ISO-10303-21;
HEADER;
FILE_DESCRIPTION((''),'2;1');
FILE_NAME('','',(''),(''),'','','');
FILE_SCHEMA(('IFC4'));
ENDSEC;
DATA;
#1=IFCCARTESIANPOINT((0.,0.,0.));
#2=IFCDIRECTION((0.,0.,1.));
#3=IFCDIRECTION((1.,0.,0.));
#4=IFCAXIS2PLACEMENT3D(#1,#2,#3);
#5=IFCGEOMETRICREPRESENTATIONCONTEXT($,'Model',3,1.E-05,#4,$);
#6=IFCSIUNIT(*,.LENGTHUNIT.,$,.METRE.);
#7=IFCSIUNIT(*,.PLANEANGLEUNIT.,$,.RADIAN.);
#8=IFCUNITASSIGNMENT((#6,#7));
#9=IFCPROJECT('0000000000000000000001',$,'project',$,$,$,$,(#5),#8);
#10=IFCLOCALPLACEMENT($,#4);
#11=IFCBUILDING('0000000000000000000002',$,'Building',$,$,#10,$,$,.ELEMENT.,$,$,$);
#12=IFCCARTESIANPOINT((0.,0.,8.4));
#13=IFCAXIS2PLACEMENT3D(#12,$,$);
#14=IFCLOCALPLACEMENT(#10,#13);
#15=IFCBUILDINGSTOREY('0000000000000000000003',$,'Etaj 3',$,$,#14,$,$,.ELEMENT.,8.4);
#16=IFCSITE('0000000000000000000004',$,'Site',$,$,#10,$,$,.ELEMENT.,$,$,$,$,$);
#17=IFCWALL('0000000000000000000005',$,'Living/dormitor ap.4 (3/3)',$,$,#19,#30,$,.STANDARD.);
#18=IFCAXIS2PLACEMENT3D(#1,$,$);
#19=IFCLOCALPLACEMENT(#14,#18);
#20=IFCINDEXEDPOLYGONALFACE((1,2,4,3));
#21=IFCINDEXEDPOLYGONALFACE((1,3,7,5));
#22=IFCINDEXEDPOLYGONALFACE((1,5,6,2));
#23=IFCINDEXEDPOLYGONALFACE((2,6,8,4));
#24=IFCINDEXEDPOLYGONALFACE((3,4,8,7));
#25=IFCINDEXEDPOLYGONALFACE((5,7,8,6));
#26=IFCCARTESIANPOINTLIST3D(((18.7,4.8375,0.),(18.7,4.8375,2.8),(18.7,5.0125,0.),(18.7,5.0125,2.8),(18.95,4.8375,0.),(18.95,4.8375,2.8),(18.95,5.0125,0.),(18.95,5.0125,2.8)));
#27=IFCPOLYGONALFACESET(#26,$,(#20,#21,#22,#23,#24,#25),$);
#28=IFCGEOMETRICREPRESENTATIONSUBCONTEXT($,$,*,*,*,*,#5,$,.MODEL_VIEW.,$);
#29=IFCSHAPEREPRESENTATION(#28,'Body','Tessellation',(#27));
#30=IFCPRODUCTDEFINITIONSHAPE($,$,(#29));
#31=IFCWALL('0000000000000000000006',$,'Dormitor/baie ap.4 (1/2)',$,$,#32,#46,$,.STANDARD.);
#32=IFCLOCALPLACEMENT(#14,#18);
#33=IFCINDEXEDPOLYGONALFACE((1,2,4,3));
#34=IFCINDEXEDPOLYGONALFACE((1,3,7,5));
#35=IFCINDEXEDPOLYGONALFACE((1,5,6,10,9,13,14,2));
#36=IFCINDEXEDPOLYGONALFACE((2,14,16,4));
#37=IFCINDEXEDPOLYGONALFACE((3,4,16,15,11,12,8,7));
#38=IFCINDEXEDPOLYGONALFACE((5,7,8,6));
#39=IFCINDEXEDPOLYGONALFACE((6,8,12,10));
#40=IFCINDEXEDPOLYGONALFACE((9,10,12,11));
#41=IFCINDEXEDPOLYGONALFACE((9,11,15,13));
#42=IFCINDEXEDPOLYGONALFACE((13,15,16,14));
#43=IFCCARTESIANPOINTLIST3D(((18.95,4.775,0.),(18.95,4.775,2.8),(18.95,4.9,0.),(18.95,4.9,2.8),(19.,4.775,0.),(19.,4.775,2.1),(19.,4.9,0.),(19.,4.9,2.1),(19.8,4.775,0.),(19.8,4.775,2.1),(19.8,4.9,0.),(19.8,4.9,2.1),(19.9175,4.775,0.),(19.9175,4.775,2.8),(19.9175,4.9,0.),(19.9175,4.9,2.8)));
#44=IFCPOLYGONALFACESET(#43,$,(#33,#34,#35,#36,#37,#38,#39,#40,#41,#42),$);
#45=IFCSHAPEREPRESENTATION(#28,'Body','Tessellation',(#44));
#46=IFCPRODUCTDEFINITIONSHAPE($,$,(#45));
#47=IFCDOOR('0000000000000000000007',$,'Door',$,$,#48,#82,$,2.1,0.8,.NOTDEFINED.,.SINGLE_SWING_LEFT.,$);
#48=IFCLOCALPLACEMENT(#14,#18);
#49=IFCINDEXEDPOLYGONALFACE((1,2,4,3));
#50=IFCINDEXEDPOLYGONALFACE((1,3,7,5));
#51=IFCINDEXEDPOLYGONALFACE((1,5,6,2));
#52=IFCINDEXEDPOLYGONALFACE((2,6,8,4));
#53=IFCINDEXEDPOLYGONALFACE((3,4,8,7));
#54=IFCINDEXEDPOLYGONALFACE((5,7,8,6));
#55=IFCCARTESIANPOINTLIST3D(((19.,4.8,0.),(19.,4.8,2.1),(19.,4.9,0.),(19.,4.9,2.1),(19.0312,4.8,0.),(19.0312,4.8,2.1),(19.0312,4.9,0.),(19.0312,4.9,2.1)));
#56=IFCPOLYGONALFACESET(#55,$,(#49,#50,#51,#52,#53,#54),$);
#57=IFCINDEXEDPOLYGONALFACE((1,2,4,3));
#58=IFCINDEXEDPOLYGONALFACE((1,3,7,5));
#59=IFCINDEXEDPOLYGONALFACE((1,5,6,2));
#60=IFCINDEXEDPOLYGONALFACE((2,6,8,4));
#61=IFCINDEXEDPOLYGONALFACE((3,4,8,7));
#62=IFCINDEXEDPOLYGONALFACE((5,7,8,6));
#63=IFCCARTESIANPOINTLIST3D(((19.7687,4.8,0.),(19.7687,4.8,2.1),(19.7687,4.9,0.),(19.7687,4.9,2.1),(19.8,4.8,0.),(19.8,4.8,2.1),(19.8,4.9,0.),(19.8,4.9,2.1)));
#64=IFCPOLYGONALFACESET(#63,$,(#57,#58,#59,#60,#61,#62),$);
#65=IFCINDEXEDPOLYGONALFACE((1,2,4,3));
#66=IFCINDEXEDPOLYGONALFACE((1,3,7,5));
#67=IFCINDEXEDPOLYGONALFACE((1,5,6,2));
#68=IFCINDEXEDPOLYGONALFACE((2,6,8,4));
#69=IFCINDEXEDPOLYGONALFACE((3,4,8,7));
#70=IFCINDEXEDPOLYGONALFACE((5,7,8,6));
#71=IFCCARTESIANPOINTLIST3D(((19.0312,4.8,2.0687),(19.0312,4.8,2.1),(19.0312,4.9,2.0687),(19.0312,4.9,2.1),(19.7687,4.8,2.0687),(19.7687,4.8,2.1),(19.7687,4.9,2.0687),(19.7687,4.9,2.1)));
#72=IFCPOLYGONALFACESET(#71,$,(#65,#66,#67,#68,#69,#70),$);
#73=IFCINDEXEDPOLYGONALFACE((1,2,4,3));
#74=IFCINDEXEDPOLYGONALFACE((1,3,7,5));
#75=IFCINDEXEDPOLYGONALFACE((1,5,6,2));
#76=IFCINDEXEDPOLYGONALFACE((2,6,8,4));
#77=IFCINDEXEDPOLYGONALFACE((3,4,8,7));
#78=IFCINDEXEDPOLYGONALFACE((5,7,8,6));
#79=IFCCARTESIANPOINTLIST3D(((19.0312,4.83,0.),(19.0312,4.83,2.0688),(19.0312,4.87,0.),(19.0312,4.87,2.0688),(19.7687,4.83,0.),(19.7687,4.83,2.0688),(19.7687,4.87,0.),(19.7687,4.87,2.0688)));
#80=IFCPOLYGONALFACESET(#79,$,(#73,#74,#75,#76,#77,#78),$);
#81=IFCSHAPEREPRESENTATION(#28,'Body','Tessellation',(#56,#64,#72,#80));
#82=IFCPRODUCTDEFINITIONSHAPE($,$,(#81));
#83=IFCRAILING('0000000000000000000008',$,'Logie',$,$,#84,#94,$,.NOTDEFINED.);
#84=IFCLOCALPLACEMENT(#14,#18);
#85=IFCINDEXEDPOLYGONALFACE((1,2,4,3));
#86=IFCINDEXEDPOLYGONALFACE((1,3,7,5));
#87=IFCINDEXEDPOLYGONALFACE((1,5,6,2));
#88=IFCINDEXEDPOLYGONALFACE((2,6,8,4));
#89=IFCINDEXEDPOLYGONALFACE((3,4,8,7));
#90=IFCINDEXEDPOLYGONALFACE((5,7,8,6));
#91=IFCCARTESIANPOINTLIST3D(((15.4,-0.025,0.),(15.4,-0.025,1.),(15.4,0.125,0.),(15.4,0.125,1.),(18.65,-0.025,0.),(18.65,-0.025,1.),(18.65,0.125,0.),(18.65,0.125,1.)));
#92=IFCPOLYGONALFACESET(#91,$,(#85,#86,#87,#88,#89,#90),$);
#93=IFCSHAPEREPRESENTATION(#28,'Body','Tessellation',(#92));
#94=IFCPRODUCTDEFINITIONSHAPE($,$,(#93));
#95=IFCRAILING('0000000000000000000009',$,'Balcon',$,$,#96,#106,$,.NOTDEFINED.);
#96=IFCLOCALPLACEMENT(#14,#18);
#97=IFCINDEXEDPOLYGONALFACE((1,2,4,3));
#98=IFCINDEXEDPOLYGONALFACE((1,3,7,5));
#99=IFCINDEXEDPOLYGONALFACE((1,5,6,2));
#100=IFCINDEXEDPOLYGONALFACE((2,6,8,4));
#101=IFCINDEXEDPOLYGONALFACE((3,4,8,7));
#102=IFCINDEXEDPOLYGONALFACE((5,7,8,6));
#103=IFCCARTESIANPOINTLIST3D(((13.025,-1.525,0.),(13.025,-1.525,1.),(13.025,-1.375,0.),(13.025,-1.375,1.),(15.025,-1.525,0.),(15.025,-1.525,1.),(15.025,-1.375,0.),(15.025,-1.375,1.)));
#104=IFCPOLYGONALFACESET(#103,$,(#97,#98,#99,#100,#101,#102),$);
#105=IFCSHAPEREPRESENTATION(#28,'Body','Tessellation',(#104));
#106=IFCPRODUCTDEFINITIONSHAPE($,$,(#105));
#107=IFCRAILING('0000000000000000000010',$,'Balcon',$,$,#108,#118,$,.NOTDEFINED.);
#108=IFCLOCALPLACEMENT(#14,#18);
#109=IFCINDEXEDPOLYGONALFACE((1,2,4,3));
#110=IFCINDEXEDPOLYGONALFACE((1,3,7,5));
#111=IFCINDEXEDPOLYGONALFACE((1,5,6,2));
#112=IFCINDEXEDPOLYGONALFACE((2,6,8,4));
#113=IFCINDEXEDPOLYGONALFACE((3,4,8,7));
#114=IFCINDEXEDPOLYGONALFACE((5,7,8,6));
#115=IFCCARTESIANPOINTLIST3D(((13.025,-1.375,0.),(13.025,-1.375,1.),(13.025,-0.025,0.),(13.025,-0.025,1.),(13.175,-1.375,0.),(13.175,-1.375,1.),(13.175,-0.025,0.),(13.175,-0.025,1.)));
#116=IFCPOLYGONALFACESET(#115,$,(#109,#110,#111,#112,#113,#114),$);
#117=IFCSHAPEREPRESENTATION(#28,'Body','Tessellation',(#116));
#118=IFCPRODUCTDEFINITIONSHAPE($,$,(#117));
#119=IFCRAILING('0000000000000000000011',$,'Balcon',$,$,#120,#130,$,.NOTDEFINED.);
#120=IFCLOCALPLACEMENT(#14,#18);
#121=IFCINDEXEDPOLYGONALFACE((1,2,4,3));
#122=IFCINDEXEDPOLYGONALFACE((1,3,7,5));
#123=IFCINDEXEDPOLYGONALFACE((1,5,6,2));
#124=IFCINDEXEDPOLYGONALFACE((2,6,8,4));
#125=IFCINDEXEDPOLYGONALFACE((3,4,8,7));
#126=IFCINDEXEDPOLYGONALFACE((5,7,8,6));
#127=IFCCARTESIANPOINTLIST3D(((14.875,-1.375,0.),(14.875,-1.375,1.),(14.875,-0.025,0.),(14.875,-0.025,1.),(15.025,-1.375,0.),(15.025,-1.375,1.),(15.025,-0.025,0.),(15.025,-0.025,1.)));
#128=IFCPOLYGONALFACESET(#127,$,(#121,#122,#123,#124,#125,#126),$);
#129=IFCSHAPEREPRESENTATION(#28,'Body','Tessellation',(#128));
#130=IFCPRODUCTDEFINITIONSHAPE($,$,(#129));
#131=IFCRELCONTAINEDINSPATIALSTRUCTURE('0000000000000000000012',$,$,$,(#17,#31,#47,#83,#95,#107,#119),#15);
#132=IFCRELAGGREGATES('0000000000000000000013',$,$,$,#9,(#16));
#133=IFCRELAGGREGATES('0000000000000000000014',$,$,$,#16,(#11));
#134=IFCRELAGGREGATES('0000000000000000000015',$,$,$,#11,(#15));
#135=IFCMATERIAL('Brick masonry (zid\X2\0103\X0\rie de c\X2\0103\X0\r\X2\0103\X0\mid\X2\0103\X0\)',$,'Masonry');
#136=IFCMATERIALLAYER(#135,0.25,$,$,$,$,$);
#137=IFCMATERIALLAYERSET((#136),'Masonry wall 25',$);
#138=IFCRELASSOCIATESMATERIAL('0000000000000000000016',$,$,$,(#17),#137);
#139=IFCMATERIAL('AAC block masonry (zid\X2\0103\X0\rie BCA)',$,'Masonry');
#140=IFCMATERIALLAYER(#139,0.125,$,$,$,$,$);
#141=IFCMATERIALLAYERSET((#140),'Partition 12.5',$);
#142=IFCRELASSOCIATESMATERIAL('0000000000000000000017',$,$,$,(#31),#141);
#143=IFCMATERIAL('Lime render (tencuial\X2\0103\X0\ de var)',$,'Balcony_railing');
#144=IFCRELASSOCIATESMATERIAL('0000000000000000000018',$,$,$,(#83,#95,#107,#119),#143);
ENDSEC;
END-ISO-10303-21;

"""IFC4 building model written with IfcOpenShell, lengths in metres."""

from ifc_helpers import new_model, si_unit, frame, frame_2d, origin, origin_with_axes, origin_2d, place, context, subcontext, project, spatial, polyline, rectangle, outline, extrude, material, layer, layer_set, layer_usage, element, fill, save


model = new_model("IFC4")

# Units and contexts
model_context = context("Model", 3, precision=1e-05, world=origin_with_axes())
sub_context = subcontext(model_context, None, None, "MODEL_VIEW")
ifc_project = project(units=[si_unit("LENGTHUNIT", "METRE"), si_unit("PLANEANGLEUNIT", "RADIAN")], contexts=[model_context])

# Site, building, storey
placement = place(None, origin_with_axes())
site = spatial("IfcSite", under=ifc_project, at=placement, Name="Site", CompositionType="ELEMENT")
building = spatial("IfcBuilding", under=site, at=placement, Name="Building", CompositionType="ELEMENT")
storey_placement = place(placement, frame((0.0, 0.0, 8.4)))
storey = spatial("IfcBuildingStorey", under=building, at=storey_placement, Name="Etaj 3", CompositionType="ELEMENT", Elevation=8.4)

# Shared definitions
ifc_material_1 = material(Name="Brick masonry (zidărie de cărămidă)", Category="Masonry")

# Wall
ifc_layer_1 = layer(ifc_material_1, 0.25)
ifc_layer_set_1 = layer_set([ifc_layer_1], Name="Masonry wall 25")
ifc_layer_usage_1 = layer_usage(ifc_layer_set_1, "AXIS2", "POSITIVE", -0.125)
wall_1_placement = place(storey_placement, frame((18.825, 4.8375, 0.0), x_axis=(0.0, 1.0, 0.0)))
element("IfcWall", 1, at=wall_1_placement, inside=storey, material=ifc_layer_usage_1, Name="Living/dormitor ap.4 (3/3)", PredefinedType="STANDARD", context=sub_context, shape_type="SweptSolid", body=[
    extrude(rectangle(XDim=0.175, YDim=0.25, at=frame_2d((0.0875, 0.0))), origin(), (0.0, 0.0, 1.0), 2.8),
])

# Wall, opening, door
ifc_material_2 = material(Name="AAC block masonry (zidărie BCA)", Category="Masonry")
ifc_layer_2 = layer(ifc_material_2, 0.125)
ifc_layer_set_2 = layer_set([ifc_layer_2], Name="Partition 12.5")
ifc_layer_usage_2 = layer_usage(ifc_layer_set_2, "AXIS2", "POSITIVE", -0.0625)
wall_2_placement = place(storey_placement, frame((18.95, 4.8375, 0.0), x_axis=(1.0, 0.0, 0.0)))
wall_2 = element("IfcWall", 2, at=wall_2_placement, inside=storey, material=ifc_layer_usage_2, Name="Dormitor/baie ap.4 (1/2)", PredefinedType="STANDARD", context=sub_context, shape_type="SweptSolid", body=[
    extrude(rectangle(XDim=0.9675, YDim=0.125, at=frame_2d((0.4838, 0.0))), origin(), (0.0, 0.0, 1.0), 2.8),
])
opening_1_placement = place(wall_2_placement, frame((0.45, 0.1125, 0.0), z_axis=(0.0, -1.0, 0.0), x_axis=(1.0, 0.0, 0.0)))
opening_1 = element("IfcOpeningElement", 3, at=opening_1_placement, cuts=wall_2, PredefinedType="OPENING", context=sub_context, shape_type="SweptSolid", body=[
    extrude(rectangle(XDim=0.8, YDim=2.1, at=frame_2d((0.0, 1.05))), origin(), (0.0, 0.0, 1.0), 0.225),
])
door_placement = place(wall_2_placement, frame((0.45, 0.0625, 0.0), z_axis=(0.0, -1.0, 0.0), x_axis=(1.0, 0.0, 0.0)))
door = element("IfcDoor", 4, at=door_placement, inside=storey, Name="Door", OperationType="SINGLE_SWING_LEFT", OverallHeight=2.1, OverallWidth=0.8, PredefinedType="NOTDEFINED", context=sub_context, shape_type="SweptSolid", body=[
    extrude(rectangle(XDim=0.0312, YDim=2.1, at=origin_2d()), frame((-0.3844, 1.05, 0.0)), (0.0, 0.0, 1.0), 0.1),
    extrude(rectangle(XDim=0.0312, YDim=2.1, at=origin_2d()), frame((0.3844, 1.05, 0.0)), (0.0, 0.0, 1.0), 0.1),
    extrude(rectangle(XDim=0.7375, YDim=0.0312, at=origin_2d()), frame((0.0, 2.0844, 0.0)), (0.0, 0.0, 1.0), 0.1),
    extrude(rectangle(XDim=0.7375, YDim=2.0688, at=origin_2d()), frame((0.0, 1.0344, 0.03)), (0.0, 0.0, 1.0), 0.04),
])
fill(opening_1, door)

# Railings
ifc_material_3 = material(Name="Lime render (tencuială de var)", Category="Balcony_railing")
railing_1_placement = place(storey_placement, frame((15.4, -0.025, 0.0), z_axis=(0.0, 0.0, 1.0), x_axis=(1.0, 0.0, 0.0)))
element("IfcRailing", 5, at=railing_1_placement, inside=storey, material=ifc_material_3, Name="Logie", PredefinedType="NOTDEFINED", context=sub_context, shape_type="SweptSolid", body=[
    extrude(outline(polyline([(0.0, 0.0), (3.25, 0.0), (3.25, 0.15), (0.0, 0.15), (0.0, 0.0)])), origin(), (0.0, 0.0, 1.0), 1.0),
])
railing_2_placement = place(storey_placement, frame((13.025, -1.525, 0.0), z_axis=(0.0, 0.0, 1.0), x_axis=(1.0, 0.0, 0.0)))
element("IfcRailing", 6, at=railing_2_placement, inside=storey, material=ifc_material_3, Name="Balcon", PredefinedType="NOTDEFINED", context=sub_context, shape_type="SweptSolid", body=[
    extrude(outline(polyline([(0.0, 0.0), (2.0, 0.0), (2.0, 0.15), (0.0, 0.15), (0.0, 0.0)])), origin(), (0.0, 0.0, 1.0), 1.0),
])
for number, where, z_axis, x_axis, name in (
    (7, (13.025, -1.375, 0.0), (0.0, 0.0, 1.0), (1.0, 0.0, 0.0), "Balcon"),
    (8, (14.875, -1.375, 0.0), (0.0, 0.0, 1.0), (1.0, 0.0, 0.0), "Balcon"),
):
    element("IfcRailing", number, at=place(storey_placement, frame(where, z_axis=z_axis, x_axis=x_axis)), inside=storey, material=ifc_material_3, Name=name, PredefinedType="NOTDEFINED", context=sub_context, shape_type="SweptSolid", body=[
        extrude(outline(polyline([(0.0, 0.0), (0.15, 0.0), (0.15, 1.35), (0.0, 1.35), (0.0, 0.0)])), origin(), (0.0, 0.0, 1.0), 1.0),
    ])

save(model, "model.ifc")
